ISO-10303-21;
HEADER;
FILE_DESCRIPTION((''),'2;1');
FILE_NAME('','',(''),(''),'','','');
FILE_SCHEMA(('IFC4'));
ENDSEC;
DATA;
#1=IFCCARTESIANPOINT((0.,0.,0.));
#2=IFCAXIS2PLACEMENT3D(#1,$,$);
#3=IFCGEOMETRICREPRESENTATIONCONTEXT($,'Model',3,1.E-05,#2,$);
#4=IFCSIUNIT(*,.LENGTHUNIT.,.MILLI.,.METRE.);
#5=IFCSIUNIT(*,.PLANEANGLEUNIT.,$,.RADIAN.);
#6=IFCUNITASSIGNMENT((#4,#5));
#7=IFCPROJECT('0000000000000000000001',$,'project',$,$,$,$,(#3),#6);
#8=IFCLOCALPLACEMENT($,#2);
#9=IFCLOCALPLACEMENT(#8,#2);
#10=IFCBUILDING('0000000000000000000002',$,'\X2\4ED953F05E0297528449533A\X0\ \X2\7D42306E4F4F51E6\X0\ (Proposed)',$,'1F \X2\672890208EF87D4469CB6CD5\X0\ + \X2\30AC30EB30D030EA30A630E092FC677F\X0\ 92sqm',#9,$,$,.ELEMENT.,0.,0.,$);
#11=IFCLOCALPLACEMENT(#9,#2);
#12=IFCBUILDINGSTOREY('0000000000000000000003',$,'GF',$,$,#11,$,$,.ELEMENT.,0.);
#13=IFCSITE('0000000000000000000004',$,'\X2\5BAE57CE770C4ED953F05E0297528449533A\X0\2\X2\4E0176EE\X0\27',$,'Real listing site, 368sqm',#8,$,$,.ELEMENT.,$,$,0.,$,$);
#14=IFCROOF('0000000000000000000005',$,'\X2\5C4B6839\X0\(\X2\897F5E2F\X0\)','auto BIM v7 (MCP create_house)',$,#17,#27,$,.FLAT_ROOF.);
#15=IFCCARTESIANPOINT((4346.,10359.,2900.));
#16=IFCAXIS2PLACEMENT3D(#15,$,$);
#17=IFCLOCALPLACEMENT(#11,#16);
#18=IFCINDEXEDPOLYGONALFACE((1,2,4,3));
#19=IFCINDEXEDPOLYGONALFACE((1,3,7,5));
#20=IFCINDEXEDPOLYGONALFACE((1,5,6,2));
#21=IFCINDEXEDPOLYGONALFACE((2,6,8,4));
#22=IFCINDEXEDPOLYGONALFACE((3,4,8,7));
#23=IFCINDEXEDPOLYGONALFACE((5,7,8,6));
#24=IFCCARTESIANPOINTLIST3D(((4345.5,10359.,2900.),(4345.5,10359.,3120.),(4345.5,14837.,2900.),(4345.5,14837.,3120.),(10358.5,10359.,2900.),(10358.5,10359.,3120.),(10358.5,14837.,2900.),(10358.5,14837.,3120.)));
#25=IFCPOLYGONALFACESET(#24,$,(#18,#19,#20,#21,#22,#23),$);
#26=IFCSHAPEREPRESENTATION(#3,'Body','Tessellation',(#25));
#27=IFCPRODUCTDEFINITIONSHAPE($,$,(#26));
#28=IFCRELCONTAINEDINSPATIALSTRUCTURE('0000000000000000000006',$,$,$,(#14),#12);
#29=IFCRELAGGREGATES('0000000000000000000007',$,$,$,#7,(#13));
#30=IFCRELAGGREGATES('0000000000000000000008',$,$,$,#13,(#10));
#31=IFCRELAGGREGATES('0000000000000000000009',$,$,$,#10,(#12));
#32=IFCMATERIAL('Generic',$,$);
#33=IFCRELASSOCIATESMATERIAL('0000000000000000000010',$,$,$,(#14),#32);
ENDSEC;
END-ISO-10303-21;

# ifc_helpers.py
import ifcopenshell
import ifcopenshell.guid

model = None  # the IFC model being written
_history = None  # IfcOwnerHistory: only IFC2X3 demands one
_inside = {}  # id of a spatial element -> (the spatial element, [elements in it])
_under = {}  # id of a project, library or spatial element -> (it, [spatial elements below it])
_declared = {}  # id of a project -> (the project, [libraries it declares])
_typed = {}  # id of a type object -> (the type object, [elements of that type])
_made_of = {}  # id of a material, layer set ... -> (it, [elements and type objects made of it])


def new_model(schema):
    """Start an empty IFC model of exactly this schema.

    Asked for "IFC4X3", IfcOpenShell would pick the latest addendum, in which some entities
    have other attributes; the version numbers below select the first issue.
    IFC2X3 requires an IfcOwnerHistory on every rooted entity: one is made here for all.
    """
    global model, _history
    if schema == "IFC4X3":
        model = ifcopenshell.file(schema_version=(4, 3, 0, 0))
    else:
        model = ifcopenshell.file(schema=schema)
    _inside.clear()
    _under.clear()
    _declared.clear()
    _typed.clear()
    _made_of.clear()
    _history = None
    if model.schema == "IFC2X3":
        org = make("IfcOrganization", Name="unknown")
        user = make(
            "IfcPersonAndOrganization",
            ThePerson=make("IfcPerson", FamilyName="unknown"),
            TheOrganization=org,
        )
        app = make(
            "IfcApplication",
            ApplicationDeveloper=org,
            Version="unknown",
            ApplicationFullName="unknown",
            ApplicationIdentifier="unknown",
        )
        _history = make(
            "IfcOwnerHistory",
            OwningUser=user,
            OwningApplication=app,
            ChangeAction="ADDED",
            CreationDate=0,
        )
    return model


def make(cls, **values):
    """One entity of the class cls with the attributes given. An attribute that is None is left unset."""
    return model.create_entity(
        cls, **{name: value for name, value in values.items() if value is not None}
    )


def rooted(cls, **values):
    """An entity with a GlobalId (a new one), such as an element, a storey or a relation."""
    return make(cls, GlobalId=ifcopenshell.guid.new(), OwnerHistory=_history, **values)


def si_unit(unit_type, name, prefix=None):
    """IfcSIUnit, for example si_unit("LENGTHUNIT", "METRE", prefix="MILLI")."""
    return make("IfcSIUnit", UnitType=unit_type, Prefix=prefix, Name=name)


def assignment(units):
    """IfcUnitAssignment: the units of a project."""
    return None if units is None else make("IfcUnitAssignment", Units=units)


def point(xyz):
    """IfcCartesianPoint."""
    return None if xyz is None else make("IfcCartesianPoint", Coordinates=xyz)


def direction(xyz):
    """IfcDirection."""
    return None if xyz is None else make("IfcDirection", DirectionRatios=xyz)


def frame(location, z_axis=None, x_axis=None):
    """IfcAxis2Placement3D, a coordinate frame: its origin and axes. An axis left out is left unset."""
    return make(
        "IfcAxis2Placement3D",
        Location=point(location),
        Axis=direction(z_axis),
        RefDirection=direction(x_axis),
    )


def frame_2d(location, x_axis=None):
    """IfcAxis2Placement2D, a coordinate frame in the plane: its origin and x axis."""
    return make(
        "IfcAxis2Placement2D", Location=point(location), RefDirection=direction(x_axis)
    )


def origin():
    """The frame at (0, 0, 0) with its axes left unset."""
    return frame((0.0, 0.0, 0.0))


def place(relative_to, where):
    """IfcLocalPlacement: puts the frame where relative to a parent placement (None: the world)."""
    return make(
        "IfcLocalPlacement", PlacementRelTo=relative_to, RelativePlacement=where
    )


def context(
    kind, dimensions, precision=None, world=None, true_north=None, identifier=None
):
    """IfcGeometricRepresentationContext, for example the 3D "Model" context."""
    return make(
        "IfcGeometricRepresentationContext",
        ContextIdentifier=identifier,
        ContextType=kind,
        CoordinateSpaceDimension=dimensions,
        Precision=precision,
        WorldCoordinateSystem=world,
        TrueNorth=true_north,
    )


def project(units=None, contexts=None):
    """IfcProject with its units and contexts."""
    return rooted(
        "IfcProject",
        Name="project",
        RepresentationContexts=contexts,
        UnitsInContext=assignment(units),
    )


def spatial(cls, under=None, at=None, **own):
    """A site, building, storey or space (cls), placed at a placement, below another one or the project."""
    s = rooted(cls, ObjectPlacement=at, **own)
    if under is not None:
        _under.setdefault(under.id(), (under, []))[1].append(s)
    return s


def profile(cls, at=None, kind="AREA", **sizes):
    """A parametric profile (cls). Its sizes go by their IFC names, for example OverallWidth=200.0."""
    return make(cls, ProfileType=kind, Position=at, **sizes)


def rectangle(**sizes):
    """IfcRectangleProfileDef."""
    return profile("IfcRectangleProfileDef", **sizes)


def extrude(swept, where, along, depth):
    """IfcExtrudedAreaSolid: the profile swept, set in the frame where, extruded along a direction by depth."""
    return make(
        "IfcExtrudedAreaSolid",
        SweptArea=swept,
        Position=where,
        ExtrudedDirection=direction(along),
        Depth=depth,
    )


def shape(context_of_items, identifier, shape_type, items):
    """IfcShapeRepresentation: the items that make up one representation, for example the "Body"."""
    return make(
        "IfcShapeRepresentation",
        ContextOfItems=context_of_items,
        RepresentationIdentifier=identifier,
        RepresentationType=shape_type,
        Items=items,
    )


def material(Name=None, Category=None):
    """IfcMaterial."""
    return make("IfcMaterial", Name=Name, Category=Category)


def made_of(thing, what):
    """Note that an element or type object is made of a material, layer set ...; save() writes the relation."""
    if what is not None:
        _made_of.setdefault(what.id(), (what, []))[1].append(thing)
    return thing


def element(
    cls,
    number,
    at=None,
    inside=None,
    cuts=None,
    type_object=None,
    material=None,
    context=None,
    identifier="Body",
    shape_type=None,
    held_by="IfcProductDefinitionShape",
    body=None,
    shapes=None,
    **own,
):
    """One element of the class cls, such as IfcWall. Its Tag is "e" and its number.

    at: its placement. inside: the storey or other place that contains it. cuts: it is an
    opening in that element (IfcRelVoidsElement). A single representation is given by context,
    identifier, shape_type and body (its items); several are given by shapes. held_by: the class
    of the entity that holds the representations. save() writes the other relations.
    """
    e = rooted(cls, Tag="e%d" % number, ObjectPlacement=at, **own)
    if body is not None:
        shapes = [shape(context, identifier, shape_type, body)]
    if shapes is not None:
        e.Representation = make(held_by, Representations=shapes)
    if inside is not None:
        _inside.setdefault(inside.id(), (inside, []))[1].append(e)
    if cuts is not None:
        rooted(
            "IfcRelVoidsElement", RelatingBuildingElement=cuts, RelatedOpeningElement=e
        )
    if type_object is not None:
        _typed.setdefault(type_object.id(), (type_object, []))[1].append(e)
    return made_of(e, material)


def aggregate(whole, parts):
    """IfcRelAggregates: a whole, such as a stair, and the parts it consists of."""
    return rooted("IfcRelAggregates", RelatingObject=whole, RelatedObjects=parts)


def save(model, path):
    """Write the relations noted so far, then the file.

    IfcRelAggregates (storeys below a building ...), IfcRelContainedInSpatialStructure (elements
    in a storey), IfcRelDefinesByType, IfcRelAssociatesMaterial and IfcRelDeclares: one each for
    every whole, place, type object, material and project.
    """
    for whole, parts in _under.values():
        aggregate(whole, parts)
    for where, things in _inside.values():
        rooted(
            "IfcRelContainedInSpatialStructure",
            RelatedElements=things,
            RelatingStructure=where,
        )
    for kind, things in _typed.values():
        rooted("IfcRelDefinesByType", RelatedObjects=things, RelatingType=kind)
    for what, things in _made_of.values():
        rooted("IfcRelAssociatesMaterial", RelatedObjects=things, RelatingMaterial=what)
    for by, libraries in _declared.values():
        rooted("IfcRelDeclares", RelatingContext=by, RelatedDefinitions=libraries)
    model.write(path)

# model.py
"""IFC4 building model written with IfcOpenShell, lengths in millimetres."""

from ifc_helpers import new_model, si_unit, frame, frame_2d, origin, place, context, project, spatial, rectangle, extrude, material, element, save


model = new_model("IFC4")

# Units and contexts
model_context = context("Model", 3, precision=1e-05, world=origin())
ifc_project = project(units=[si_unit("LENGTHUNIT", "METRE", prefix="MILLI"), si_unit("PLANEANGLEUNIT", "RADIAN")], contexts=[model_context])

# Site, building, storey
site_placement = place(None, origin())
site = spatial("IfcSite", under=ifc_project, at=site_placement, Name="宮城県仙台市青葉区2丁目27", ObjectType="Real listing site, 368sqm", CompositionType="ELEMENT", RefElevation=0.0)
building_placement = place(site_placement, origin())
building = spatial("IfcBuilding", under=site, at=building_placement, Name="仙台市青葉区 終の住処 (Proposed)", ObjectType="1F 木造軸組構法 + ガルバリウム鋼板 92sqm", CompositionType="ELEMENT", ElevationOfRefHeight=0.0, ElevationOfTerrain=0.0)
storey_placement = place(building_placement, origin())
storey = spatial("IfcBuildingStorey", under=building, at=storey_placement, Name="GF", CompositionType="ELEMENT", Elevation=0.0)

# Shared definitions
ifc_material = material(Name="Generic")

# Roof
roof_1_placement = place(storey_placement, frame((4346.0, 10359.0, 2900.0)))
element("IfcRoof", 1, at=roof_1_placement, inside=storey, material=ifc_material, Name="屋根(西帯)", Description="auto BIM v7 (MCP create_house)", PredefinedType="FLAT_ROOF", context=model_context, shape_type="SweptSolid", body=[
    extrude(rectangle(XDim=6013.0, YDim=4478.0, at=frame_2d((3006.0, 2239.0))), frame((4346.0, 10359.0, 2900.0)), (0.0, 0.0, 1.0), 220.0),
])

save(model, "model.ifc")
